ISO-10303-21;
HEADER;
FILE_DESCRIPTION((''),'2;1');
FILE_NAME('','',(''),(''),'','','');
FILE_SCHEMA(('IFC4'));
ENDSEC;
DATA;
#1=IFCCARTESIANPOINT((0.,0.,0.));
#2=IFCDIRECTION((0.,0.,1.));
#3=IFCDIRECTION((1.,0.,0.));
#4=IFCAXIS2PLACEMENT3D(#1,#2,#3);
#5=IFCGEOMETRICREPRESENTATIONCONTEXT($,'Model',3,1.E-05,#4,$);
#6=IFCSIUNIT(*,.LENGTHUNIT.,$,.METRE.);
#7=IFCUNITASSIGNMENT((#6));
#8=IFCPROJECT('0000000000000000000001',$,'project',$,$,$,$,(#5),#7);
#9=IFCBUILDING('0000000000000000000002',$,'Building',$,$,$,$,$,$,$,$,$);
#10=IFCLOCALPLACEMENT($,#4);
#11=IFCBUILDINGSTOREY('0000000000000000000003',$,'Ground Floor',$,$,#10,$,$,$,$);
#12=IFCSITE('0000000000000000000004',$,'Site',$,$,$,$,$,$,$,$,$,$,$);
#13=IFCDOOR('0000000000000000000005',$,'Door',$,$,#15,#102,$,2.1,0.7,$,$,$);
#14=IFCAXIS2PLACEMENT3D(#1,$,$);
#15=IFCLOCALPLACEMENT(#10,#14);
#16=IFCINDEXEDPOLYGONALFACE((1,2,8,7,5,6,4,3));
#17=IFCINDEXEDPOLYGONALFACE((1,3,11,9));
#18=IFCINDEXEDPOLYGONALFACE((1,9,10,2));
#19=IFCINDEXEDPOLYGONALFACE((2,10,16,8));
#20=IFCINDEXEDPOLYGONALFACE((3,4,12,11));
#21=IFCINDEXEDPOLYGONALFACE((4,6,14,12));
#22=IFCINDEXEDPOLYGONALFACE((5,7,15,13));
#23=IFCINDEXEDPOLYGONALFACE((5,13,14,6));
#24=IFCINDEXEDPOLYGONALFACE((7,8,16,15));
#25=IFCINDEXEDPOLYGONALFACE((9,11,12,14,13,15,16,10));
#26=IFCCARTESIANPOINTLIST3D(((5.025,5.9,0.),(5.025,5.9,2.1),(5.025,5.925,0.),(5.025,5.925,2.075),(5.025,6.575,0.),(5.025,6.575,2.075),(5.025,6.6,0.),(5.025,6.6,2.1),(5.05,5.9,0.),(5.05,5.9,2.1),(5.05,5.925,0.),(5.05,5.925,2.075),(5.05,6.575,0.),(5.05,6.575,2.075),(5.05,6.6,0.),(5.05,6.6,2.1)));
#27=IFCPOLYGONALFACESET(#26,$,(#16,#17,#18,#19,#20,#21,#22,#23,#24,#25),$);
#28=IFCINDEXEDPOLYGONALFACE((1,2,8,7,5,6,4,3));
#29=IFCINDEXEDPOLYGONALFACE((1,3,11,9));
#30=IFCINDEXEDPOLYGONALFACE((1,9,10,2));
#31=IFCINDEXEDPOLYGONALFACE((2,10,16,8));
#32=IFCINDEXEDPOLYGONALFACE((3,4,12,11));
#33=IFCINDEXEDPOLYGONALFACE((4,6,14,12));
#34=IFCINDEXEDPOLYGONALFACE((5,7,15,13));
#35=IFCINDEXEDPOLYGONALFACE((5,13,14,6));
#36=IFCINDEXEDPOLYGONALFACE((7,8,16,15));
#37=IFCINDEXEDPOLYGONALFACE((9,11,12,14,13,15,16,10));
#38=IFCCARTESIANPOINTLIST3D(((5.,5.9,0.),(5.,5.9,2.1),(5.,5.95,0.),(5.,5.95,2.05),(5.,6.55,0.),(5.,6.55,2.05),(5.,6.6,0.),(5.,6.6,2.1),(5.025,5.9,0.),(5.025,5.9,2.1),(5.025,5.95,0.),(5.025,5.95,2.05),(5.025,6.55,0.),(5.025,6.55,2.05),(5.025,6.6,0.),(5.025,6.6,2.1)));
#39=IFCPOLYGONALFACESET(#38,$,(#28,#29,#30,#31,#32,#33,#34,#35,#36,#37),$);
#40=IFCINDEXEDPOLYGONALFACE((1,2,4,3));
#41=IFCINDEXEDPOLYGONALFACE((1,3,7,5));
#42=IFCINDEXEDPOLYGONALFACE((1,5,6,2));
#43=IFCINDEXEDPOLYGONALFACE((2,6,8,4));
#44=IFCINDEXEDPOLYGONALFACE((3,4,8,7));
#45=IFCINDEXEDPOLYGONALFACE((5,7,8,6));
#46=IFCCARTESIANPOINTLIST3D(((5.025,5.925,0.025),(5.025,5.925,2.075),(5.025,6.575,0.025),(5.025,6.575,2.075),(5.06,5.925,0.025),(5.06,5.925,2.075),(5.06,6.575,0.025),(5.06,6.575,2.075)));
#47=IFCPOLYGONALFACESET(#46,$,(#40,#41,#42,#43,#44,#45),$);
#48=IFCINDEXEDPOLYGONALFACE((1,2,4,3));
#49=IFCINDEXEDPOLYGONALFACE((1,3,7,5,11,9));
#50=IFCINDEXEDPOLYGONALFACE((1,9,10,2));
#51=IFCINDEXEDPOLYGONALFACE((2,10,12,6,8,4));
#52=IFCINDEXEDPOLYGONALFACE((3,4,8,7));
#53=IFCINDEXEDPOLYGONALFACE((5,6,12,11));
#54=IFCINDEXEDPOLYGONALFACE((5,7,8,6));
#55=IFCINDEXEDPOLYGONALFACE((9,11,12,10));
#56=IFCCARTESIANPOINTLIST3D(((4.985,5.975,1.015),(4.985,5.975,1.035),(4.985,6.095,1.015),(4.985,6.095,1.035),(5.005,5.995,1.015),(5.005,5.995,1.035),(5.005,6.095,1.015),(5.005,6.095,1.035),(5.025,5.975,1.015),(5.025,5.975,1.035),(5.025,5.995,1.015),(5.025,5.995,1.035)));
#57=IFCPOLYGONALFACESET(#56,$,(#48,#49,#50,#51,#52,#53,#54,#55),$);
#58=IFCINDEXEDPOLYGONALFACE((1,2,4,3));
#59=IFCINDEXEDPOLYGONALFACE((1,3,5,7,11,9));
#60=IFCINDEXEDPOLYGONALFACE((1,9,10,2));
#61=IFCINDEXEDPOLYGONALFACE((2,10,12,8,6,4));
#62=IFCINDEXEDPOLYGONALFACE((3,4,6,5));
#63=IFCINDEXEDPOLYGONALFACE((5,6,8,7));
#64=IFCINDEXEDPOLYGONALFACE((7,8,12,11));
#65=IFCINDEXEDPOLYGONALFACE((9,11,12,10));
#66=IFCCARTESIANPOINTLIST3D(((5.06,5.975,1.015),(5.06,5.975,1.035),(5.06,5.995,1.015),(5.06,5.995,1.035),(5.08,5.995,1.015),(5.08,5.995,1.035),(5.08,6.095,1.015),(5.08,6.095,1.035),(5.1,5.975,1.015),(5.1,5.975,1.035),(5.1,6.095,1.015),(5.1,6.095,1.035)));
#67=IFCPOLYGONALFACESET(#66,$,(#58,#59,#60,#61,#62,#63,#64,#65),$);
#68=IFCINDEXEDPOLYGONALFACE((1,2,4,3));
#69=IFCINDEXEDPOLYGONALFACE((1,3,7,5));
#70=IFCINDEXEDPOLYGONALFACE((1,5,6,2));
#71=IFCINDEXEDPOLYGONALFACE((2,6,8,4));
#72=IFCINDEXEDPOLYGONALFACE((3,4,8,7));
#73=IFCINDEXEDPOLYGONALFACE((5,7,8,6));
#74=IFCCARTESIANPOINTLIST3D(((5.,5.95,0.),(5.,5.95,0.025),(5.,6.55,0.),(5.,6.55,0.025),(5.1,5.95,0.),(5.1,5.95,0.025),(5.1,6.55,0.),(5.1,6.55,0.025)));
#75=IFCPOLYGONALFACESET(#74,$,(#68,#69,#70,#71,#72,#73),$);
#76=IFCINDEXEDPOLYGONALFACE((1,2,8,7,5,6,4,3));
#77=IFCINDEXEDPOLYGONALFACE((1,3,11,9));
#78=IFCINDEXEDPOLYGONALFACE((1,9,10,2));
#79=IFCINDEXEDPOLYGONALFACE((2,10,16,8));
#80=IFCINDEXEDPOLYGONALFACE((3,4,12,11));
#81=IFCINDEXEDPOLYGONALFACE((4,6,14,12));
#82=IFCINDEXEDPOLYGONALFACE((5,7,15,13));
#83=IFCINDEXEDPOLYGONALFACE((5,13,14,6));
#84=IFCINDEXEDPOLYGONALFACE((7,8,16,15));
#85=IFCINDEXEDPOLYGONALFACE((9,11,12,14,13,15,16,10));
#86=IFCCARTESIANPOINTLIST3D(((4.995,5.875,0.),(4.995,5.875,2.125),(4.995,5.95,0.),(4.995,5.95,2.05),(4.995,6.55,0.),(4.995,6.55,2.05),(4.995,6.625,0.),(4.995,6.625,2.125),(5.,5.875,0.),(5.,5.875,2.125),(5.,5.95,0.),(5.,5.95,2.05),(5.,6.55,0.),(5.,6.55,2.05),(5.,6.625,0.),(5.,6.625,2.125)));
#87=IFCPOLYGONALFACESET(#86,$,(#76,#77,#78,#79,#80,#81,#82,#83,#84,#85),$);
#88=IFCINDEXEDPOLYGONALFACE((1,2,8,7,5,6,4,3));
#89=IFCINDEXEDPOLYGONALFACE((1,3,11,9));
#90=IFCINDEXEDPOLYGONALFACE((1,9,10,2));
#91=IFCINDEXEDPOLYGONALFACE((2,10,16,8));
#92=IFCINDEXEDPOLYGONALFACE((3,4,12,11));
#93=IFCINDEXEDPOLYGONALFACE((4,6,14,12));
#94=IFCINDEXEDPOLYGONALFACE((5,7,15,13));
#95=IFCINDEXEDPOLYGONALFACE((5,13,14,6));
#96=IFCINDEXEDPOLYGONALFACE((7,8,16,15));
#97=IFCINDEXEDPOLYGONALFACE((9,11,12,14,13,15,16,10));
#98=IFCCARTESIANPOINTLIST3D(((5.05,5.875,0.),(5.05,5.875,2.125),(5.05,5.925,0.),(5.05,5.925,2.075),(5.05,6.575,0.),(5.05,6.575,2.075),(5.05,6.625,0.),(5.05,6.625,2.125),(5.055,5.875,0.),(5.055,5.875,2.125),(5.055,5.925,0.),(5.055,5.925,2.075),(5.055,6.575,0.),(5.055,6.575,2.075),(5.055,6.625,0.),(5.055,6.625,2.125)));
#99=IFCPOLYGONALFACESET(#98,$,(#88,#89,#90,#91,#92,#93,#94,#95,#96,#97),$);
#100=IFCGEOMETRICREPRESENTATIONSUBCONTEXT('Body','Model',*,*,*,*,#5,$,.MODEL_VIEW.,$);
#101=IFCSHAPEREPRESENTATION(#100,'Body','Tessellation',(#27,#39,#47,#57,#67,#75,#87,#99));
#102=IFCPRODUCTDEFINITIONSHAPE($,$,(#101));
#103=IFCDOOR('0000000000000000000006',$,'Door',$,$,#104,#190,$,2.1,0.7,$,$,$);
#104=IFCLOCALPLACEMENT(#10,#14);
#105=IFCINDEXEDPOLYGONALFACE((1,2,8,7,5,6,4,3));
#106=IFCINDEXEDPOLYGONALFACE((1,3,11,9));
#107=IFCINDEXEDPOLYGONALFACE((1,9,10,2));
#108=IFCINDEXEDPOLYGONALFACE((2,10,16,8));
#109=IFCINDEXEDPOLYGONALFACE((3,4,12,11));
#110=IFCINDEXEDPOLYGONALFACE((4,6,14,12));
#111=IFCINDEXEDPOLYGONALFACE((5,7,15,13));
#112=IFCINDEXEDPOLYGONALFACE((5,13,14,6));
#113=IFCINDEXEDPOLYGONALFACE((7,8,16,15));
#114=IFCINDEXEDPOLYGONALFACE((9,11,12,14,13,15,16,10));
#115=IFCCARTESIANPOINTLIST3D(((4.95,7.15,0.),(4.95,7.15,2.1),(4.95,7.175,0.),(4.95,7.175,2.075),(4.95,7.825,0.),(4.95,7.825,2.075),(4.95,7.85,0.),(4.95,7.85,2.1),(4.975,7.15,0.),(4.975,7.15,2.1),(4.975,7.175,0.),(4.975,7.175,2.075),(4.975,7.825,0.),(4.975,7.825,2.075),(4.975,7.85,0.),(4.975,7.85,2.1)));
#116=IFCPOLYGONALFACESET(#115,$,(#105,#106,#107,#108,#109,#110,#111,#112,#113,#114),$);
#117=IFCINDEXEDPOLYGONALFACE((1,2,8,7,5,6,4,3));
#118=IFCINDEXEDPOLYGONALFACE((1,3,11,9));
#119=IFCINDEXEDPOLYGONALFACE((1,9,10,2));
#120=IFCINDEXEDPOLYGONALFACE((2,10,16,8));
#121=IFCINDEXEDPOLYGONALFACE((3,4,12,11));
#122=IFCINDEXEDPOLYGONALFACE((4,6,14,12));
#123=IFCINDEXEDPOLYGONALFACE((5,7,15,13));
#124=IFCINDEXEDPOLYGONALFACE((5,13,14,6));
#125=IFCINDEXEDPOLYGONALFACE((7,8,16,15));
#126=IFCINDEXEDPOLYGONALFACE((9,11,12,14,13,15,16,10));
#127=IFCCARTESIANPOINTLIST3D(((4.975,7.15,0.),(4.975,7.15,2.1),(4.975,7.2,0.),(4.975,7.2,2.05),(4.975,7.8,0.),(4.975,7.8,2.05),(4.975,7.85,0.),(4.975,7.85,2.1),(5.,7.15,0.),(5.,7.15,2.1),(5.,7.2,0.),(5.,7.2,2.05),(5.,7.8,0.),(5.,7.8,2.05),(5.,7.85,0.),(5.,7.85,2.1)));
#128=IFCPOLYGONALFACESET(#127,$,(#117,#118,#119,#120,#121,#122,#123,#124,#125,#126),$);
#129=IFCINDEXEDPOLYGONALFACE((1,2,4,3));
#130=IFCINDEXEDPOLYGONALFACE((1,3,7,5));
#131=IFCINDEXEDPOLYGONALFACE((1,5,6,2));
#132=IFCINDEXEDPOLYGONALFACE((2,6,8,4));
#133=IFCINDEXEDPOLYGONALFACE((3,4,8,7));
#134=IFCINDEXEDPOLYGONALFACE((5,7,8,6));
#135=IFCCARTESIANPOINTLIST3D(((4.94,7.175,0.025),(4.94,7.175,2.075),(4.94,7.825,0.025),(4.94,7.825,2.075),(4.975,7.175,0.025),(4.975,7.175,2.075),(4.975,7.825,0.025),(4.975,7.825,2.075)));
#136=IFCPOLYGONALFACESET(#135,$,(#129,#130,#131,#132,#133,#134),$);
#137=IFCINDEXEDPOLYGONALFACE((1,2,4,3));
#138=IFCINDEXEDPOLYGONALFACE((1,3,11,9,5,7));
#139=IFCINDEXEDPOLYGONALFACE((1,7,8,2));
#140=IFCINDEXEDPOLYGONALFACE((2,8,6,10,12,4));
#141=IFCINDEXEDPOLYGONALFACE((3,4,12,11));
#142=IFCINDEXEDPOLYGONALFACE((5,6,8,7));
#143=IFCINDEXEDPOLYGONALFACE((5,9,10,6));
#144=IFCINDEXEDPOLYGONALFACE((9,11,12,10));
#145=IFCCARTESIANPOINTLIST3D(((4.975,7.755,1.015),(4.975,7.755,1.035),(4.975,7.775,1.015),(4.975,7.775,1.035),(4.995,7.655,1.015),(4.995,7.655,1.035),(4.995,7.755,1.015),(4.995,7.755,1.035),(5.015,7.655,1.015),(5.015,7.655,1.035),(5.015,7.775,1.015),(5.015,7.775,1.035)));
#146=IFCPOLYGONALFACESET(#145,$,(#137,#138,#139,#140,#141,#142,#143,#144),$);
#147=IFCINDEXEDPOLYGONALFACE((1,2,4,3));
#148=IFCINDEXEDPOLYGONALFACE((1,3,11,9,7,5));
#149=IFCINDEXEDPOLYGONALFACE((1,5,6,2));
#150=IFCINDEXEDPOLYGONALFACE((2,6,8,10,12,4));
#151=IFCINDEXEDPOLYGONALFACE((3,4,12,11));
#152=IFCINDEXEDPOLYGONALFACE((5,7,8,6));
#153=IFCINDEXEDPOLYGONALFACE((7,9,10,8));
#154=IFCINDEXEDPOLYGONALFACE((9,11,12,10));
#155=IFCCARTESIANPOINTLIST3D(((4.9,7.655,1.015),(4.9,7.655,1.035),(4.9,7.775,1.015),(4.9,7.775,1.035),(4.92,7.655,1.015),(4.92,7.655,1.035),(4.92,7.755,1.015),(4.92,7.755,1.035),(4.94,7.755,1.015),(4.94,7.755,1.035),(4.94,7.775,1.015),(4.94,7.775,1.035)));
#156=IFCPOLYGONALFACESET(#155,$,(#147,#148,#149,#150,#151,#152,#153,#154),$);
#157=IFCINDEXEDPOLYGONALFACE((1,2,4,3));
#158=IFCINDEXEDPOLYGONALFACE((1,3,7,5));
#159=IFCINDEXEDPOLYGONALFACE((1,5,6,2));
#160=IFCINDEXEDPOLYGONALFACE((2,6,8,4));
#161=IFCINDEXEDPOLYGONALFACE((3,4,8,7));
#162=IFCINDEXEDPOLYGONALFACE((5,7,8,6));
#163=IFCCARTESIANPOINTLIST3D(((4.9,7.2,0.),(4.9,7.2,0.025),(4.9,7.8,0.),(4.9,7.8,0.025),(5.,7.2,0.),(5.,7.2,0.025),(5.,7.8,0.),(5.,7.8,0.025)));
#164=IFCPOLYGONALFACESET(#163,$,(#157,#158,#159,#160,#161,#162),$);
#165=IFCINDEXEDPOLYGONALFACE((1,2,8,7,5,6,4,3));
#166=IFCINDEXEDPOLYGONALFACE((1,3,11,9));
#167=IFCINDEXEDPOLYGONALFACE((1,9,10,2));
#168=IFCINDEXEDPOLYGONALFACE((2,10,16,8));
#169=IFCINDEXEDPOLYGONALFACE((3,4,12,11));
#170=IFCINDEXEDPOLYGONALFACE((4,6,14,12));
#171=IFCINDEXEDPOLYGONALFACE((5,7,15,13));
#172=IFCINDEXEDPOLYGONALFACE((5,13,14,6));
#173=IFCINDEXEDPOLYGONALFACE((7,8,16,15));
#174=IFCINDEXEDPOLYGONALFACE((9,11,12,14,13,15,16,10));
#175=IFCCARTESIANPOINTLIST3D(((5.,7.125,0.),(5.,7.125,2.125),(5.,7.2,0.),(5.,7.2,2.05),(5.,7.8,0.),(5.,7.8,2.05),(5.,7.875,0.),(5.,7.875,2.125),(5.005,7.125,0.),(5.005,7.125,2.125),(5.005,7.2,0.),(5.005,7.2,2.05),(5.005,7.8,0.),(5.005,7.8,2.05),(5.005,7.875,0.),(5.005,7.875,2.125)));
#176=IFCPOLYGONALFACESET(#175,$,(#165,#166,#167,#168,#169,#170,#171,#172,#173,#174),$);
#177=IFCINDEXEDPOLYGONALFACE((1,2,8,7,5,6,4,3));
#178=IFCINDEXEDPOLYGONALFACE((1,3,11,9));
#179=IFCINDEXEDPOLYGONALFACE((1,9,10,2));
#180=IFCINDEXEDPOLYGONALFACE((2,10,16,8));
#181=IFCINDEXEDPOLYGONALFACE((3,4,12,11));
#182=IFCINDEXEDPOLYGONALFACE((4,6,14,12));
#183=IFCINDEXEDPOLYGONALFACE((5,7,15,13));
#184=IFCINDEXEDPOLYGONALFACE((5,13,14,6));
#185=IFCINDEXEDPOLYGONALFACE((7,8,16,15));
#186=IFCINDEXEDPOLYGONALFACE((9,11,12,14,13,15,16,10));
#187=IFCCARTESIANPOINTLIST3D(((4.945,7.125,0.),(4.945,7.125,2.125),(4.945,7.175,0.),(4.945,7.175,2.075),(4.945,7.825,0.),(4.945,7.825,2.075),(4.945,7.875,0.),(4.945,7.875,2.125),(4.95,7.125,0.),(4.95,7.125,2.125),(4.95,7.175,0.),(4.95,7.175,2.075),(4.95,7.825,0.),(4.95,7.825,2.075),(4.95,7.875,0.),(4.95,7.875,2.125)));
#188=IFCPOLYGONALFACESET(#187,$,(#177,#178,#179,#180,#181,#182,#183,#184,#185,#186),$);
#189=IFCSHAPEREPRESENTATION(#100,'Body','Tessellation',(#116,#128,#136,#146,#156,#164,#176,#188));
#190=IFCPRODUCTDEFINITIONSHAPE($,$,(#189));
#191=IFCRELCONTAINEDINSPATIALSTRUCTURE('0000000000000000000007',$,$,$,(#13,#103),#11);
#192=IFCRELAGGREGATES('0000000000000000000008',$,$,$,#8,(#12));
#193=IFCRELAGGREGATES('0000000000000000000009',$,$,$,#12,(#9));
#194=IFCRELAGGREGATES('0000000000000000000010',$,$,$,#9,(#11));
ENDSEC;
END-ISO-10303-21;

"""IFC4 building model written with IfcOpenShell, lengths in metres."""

from ifc_helpers import new_model, si_unit, frame, origin_with_axes, place, context, subcontext, project, spatial, line, indexed_curve, outline, extrude, element, save


model = new_model("IFC4")

# Units and contexts
model_context = context("Model", 3, precision=1e-05, world=origin_with_axes())
body_context = subcontext(model_context, "Body", "Model", "MODEL_VIEW")
ifc_project = project(units=[si_unit("LENGTHUNIT", "METRE")], contexts=[model_context])

# Site, building, storey
site = spatial("IfcSite", under=ifc_project, Name="Site")
building = spatial("IfcBuilding", under=site, Name="Building")
storey_placement = place(None, origin_with_axes())
storey = spatial("IfcBuildingStorey", under=building, at=storey_placement, Name="Ground Floor")

# Doors
door_1_placement = place(storey_placement, frame((5.0, 6.6, 0.0), z_axis=(0.0, 0.0, 1.0), x_axis=(0.0, -1.0, 0.0)))
element("IfcDoor", 1, at=door_1_placement, inside=storey, Name="Door", OverallHeight=2.1, OverallWidth=0.7, context=body_context, shape_type="SweptSolid", body=[
    extrude(outline(indexed_curve([(0.0, 0.0), (0.0, 2.1), (0.7, 2.1), (0.7, 0.0), (0.675, 0.0), (0.675, 2.075), (0.025, 2.075), (0.025, 0.0)], segments=[line(1, 2, 3, 4, 5, 6, 7, 8, 1)])), frame((0.0, 0.025, 0.0), z_axis=(0.0, -1.0, 0.0), x_axis=(1.0, 0.0, 0.0)), (0.0, 0.0, -1.0), 0.025),
    extrude(outline(indexed_curve([(0.0, 0.0), (0.0, 2.1), (0.7, 2.1), (0.7, 0.0), (0.65, 0.0), (0.65, 2.05), (0.05, 2.05), (0.05, 0.0)], segments=[line(1, 2, 3, 4, 5, 6, 7, 8, 1)])), frame((0.0, 0.0, 0.0), z_axis=(0.0, -1.0, 0.0), x_axis=(1.0, 0.0, 0.0)), (0.0, 0.0, -1.0), 0.025),
    extrude(outline(indexed_curve([(0.0, 0.0), (0.65, 0.0), (0.65, 0.035), (0.0, 0.035)], segments=[line(1, 2, 3, 4, 1)])), frame((0.025, 0.025, 0.025), z_axis=(0.0, 0.0, 1.0), x_axis=(1.0, 0.0, 0.0)), (0.0, 0.0, 1.0), 2.05),
    extrude(outline(indexed_curve([(0.0, 0.0), (0.0, -0.04), (-0.12, -0.04), (-0.12, -0.02), (-0.02, -0.02), (-0.02, 0.0)], segments=[line(1, 2, 3, 4, 5, 6, 1)])), frame((0.625, 0.025, 1.015), z_axis=(0.0, 0.0, 1.0), x_axis=(1.0, 0.0, 0.0)), (0.0, 0.0, 1.0), 0.02),
    extrude(outline(indexed_curve([(0.0, 0.0), (0.0, 0.04), (-0.12, 0.04), (-0.12, 0.02), (-0.02, 0.02), (-0.02, 0.0)], segments=[line(1, 2, 3, 4, 5, 6, 1)])), frame((0.625, 0.06, 1.015), z_axis=(0.0, 0.0, 1.0), x_axis=(1.0, 0.0, 0.0)), (0.0, 0.0, 1.0), 0.02),
    extrude(outline(indexed_curve([(0.0, 0.0), (0.6, 0.0), (0.6, 0.1), (0.0, 0.1)], segments=[line(1, 2, 3, 4, 1)])), frame((0.05, 0.0, 0.0), z_axis=(0.0, 0.0, 1.0), x_axis=(1.0, 0.0, 0.0)), (0.0, 0.0, 1.0), 0.025),
    extrude(outline(indexed_curve([(0.0, 0.0), (0.0, 2.125), (0.75, 2.125), (0.75, 0.0), (0.675, 0.0), (0.675, 2.05), (0.075, 2.05), (0.075, 0.0)], segments=[line(1, 2, 3, 4, 5, 6, 7, 8, 1)])), frame((-0.025, -0.005, 0.0), z_axis=(0.0, -1.0, 0.0), x_axis=(1.0, 0.0, 0.0)), (0.0, 0.0, -1.0), 0.005),
    extrude(outline(indexed_curve([(0.0, 0.0), (0.0, 2.125), (0.75, 2.125), (0.75, 0.0), (0.7, 0.0), (0.7, 2.075), (0.05, 2.075), (0.05, 0.0)], segments=[line(1, 2, 3, 4, 5, 6, 7, 8, 1)])), frame((-0.025, 0.05, 0.0), z_axis=(0.0, -1.0, 0.0), x_axis=(1.0, 0.0, 0.0)), (0.0, 0.0, -1.0), 0.005),
])
door_2_placement = place(storey_placement, frame((5.0, 7.15, 0.0), z_axis=(0.0, 0.0, 1.0), x_axis=(0.0, 1.0, 0.0)))
element("IfcDoor", 2, at=door_2_placement, inside=storey, Name="Door", OverallHeight=2.1, OverallWidth=0.7, context=body_context, shape_type="SweptSolid", body=[
    extrude(outline(indexed_curve([(0.0, 0.0), (0.0, 2.1), (0.7, 2.1), (0.7, 0.0), (0.675, 0.0), (0.675, 2.075), (0.025, 2.075), (0.025, 0.0)], segments=[line(1, 2, 3, 4, 5, 6, 7, 8, 1)])), frame((0.0, 0.025, 0.0), z_axis=(0.0, -1.0, 0.0), x_axis=(1.0, 0.0, 0.0)), (0.0, 0.0, -1.0), 0.025),
    extrude(outline(indexed_curve([(0.0, 0.0), (0.0, 2.1), (0.7, 2.1), (0.7, 0.0), (0.65, 0.0), (0.65, 2.05), (0.05, 2.05), (0.05, 0.0)], segments=[line(1, 2, 3, 4, 5, 6, 7, 8, 1)])), frame((0.0, 0.0, 0.0), z_axis=(0.0, -1.0, 0.0), x_axis=(1.0, 0.0, 0.0)), (0.0, 0.0, -1.0), 0.025),
    extrude(outline(indexed_curve([(0.0, 0.0), (0.65, 0.0), (0.65, 0.035), (0.0, 0.035)], segments=[line(1, 2, 3, 4, 1)])), frame((0.025, 0.025, 0.025), z_axis=(0.0, 0.0, 1.0), x_axis=(1.0, 0.0, 0.0)), (0.0, 0.0, 1.0), 2.05),
    extrude(outline(indexed_curve([(0.0, 0.0), (0.0, -0.04), (-0.12, -0.04), (-0.12, -0.02), (-0.02, -0.02), (-0.02, 0.0)], segments=[line(1, 2, 3, 4, 5, 6, 1)])), frame((0.625, 0.025, 1.015), z_axis=(0.0, 0.0, 1.0), x_axis=(1.0, 0.0, 0.0)), (0.0, 0.0, 1.0), 0.02),
    extrude(outline(indexed_curve([(0.0, 0.0), (0.0, 0.04), (-0.12, 0.04), (-0.12, 0.02), (-0.02, 0.02), (-0.02, 0.0)], segments=[line(1, 2, 3, 4, 5, 6, 1)])), frame((0.625, 0.06, 1.015), z_axis=(0.0, 0.0, 1.0), x_axis=(1.0, 0.0, 0.0)), (0.0, 0.0, 1.0), 0.02),
    extrude(outline(indexed_curve([(0.0, 0.0), (0.6, 0.0), (0.6, 0.1), (0.0, 0.1)], segments=[line(1, 2, 3, 4, 1)])), frame((0.05, 0.0, 0.0), z_axis=(0.0, 0.0, 1.0), x_axis=(1.0, 0.0, 0.0)), (0.0, 0.0, 1.0), 0.025),
    extrude(outline(indexed_curve([(0.0, 0.0), (0.0, 2.125), (0.75, 2.125), (0.75, 0.0), (0.675, 0.0), (0.675, 2.05), (0.075, 2.05), (0.075, 0.0)], segments=[line(1, 2, 3, 4, 5, 6, 7, 8, 1)])), frame((-0.025, -0.005, 0.0), z_axis=(0.0, -1.0, 0.0), x_axis=(1.0, 0.0, 0.0)), (0.0, 0.0, -1.0), 0.005),
    extrude(outline(indexed_curve([(0.0, 0.0), (0.0, 2.125), (0.75, 2.125), (0.75, 0.0), (0.7, 0.0), (0.7, 2.075), (0.05, 2.075), (0.05, 0.0)], segments=[line(1, 2, 3, 4, 5, 6, 7, 8, 1)])), frame((-0.025, 0.05, 0.0), z_axis=(0.0, -1.0, 0.0), x_axis=(1.0, 0.0, 0.0)), (0.0, 0.0, -1.0), 0.005),
])

save(model, "model.ifc")
